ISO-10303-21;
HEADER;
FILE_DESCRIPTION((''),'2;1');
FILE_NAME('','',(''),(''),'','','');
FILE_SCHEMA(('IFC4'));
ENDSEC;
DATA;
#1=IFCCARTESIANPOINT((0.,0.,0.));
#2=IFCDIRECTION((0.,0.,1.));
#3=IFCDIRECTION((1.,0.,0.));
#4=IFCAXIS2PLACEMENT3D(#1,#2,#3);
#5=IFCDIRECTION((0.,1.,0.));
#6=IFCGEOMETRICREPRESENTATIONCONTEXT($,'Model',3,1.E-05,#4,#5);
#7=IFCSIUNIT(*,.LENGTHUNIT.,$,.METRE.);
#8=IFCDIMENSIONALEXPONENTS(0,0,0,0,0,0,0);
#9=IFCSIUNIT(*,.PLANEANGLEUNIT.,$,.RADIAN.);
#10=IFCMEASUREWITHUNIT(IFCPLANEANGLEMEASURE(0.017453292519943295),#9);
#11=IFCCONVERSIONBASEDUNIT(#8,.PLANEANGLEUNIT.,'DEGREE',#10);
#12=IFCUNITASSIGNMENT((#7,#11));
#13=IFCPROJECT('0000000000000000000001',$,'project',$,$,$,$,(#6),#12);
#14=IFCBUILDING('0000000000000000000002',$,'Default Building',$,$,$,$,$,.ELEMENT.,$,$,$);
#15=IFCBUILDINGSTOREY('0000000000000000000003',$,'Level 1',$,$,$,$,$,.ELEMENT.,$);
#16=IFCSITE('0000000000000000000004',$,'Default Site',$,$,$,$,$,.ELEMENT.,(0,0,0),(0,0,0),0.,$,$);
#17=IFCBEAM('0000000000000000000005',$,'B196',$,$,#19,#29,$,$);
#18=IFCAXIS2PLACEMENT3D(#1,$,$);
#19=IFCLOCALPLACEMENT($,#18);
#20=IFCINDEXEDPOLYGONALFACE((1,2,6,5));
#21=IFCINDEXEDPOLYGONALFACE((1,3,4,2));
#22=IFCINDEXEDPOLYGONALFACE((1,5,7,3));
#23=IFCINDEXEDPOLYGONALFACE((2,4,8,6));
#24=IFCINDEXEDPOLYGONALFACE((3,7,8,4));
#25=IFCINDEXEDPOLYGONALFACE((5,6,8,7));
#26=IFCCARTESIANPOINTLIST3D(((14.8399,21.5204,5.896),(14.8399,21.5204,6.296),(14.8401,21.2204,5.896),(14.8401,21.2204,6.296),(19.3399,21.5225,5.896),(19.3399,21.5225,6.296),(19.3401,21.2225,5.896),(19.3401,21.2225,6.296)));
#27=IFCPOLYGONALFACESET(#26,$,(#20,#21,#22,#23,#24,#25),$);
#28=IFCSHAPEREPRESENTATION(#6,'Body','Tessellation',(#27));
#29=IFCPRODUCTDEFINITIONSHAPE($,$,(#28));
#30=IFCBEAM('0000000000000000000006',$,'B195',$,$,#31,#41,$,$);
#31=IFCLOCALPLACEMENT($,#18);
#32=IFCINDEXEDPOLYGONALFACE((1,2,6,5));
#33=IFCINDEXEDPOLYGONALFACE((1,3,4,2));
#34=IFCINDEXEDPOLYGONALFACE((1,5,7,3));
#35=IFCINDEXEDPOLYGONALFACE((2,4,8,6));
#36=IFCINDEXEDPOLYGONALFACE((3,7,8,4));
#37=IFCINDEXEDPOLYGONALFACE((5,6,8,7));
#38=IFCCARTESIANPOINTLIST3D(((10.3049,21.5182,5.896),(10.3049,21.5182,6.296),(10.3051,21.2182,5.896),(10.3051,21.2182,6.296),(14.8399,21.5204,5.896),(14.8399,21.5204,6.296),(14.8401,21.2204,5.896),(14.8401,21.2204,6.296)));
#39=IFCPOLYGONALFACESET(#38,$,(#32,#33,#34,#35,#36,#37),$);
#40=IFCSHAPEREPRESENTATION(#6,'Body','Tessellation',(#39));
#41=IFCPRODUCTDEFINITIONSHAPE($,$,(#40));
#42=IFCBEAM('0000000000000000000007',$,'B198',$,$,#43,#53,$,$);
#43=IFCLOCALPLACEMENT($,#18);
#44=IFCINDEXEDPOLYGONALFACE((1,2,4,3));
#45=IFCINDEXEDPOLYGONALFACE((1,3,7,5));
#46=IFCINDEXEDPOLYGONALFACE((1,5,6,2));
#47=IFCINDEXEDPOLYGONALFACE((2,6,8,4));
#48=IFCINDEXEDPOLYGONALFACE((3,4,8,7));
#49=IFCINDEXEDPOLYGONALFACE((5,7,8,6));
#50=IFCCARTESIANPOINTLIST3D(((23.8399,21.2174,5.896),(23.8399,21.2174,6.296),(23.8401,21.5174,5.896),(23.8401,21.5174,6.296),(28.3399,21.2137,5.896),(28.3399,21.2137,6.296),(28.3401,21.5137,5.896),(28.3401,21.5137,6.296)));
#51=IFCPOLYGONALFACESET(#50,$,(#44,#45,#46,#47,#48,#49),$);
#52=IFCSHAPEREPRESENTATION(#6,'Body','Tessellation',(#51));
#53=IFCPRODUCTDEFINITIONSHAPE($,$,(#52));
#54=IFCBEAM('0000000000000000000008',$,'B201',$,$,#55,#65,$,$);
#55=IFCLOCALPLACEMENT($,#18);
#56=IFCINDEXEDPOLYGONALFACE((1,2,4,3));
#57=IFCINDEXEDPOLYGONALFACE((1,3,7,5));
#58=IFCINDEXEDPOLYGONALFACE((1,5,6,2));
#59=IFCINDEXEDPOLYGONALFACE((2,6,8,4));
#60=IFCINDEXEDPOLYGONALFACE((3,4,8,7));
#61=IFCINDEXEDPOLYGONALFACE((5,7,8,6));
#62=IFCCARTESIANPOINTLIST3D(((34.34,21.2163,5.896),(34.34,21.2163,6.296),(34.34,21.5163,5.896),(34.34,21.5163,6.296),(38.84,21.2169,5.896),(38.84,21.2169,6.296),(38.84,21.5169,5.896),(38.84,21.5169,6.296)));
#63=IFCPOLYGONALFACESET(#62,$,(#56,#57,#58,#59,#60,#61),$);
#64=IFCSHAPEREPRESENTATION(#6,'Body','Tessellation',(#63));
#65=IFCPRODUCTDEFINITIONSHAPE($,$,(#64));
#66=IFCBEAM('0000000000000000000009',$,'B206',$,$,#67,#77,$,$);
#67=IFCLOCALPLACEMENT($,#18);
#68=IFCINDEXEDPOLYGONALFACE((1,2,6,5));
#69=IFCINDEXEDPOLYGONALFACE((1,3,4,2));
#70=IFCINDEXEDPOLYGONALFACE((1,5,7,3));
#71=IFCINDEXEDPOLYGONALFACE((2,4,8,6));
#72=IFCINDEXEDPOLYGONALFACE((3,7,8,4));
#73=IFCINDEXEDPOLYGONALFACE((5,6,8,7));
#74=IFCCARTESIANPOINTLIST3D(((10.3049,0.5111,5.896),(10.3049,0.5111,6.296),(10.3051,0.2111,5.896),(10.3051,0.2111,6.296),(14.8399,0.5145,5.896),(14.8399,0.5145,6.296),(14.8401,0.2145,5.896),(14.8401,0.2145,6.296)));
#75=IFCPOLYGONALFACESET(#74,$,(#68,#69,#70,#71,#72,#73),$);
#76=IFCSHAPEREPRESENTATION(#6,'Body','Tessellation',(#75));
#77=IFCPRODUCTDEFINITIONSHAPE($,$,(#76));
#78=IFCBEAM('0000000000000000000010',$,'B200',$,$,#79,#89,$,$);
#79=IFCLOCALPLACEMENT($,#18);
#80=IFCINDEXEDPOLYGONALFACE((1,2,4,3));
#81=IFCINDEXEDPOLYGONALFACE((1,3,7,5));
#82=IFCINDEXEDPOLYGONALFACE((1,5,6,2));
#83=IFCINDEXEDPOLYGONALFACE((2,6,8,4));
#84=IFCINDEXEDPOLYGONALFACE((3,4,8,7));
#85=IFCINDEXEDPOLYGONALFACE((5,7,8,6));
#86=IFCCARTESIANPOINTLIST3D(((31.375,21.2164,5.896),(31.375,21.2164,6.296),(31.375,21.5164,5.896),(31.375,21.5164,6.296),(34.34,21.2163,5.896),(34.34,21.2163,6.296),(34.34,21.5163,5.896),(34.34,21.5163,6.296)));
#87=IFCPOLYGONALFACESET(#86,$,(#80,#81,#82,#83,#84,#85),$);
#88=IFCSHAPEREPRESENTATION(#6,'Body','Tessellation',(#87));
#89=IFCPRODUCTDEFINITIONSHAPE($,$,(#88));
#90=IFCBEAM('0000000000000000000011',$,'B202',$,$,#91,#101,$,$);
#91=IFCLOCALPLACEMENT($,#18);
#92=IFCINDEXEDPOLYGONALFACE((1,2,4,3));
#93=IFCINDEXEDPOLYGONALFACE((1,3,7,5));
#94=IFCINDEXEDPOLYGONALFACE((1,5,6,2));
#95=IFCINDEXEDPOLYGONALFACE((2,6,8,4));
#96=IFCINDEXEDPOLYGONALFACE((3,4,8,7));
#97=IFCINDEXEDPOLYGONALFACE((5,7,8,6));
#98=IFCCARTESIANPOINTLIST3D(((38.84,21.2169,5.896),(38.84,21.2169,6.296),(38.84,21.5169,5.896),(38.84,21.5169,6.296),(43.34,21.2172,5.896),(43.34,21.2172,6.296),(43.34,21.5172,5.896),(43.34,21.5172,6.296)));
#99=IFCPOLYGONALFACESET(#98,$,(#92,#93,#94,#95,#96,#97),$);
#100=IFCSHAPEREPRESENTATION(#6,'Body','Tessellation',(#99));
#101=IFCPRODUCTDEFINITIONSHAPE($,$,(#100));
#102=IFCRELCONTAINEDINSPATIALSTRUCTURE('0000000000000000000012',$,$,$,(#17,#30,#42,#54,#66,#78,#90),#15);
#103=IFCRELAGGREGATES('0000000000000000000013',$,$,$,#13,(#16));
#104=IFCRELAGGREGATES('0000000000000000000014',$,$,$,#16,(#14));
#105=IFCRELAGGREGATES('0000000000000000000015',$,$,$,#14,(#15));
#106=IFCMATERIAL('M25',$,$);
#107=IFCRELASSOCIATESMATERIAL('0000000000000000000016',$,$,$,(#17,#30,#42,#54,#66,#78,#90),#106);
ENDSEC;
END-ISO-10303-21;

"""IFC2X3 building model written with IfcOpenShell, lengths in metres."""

from ifc_helpers import new_model, entity, si_unit, converted_unit, direction, frame, frame_2d, origin_with_axes, place, context, project, spatial, rectangle, extrude, material, element, save


model = new_model("IFC2X3")

# Units and contexts
model_context = context("Model", 3, precision=1e-05, world=origin_with_axes(), true_north=direction((0.0, 1.0, 0.0)))
ifc_project = project(units=[si_unit("LENGTHUNIT", "METRE"), converted_unit("PLANEANGLEUNIT", "DEGREE", entity("IfcPlaneAngleMeasure", 0.017453292519943295), si_unit("PLANEANGLEUNIT", "RADIAN"), dimensions=[0, 0, 0, 0, 0, 0, 0])], contexts=[model_context])

# Site, building, storey
site = spatial("IfcSite", under=ifc_project, Name="Default Site", CompositionType="ELEMENT", RefLatitude=(0, 0, 0), RefLongitude=(0, 0, 0), RefElevation=0.0)
building = spatial("IfcBuilding", under=site, Name="Default Building", CompositionType="ELEMENT")
storey = spatial("IfcBuildingStorey", under=building, Name="Level 1", CompositionType="ELEMENT")

# Shared definitions
ifc_material = material(Name="M25")
placement = place(None, origin_with_axes())

# Beams
element("IfcBeam", 1, at=placement, inside=storey, material=ifc_material, Name="B196", context=model_context, shape_type="SweptSolid", body=[
    extrude(rectangle(XDim=0.3, YDim=0.4, at=frame_2d((0.0, 0.0), x_axis=(0.0, 1.0, 0.0))), frame((14.84, 21.3704, 6.096), z_axis=(1.0, 0.000471, 0.0), x_axis=(0.0, 0.0, -1.0)), (0.0, 0.0, 1.0), 4.5),
])
element("IfcBeam", 2, at=placement, inside=storey, material=ifc_material, Name="B195", context=model_context, shape_type="SweptSolid", body=[
    extrude(rectangle(XDim=0.3, YDim=0.4, at=frame_2d((0.0, 0.0), x_axis=(0.0, 1.0, 0.0))), frame((10.305, 21.3682, 6.096), z_axis=(1.0, 0.000476, 0.0), x_axis=(0.0, 0.0, -1.0)), (0.0, 0.0, 1.0), 4.535),
])
element("IfcBeam", 3, at=placement, inside=storey, material=ifc_material, Name="B198", context=model_context, shape_type="SweptSolid", body=[
    extrude(rectangle(XDim=0.3, YDim=0.4, at=frame_2d((0.0, 0.0), x_axis=(0.0, 1.0, 0.0))), frame((23.84, 21.3674, 6.096), z_axis=(1.0, -0.000812, 0.0), x_axis=(0.0, 0.0, -1.0)), (0.0, 0.0, 1.0), 4.5),
])
element("IfcBeam", 4, at=placement, inside=storey, material=ifc_material, Name="B201", context=model_context, shape_type="SweptSolid", body=[
    extrude(rectangle(XDim=0.3, YDim=0.4, at=frame_2d((0.0, 0.0), x_axis=(0.0, 1.0, 0.0))), frame((34.34, 21.3663, 6.096), z_axis=(1.0, 0.000136, 0.0), x_axis=(0.0, 0.0, -1.0)), (0.0, 0.0, 1.0), 4.5),
])
element("IfcBeam", 5, at=placement, inside=storey, material=ifc_material, Name="B206", context=model_context, shape_type="SweptSolid", body=[
    extrude(rectangle(XDim=0.3, YDim=0.4, at=frame_2d((0.0, 0.0), x_axis=(0.0, 1.0, 0.0))), frame((10.305, 0.3611, 6.096), z_axis=(1.0, 0.000762, 0.0), x_axis=(0.0, 0.0, -1.0)), (0.0, 0.0, 1.0), 4.535),
])
element("IfcBeam", 6, at=placement, inside=storey, material=ifc_material, Name="B200", context=model_context, shape_type="SweptSolid", body=[
    extrude(rectangle(XDim=0.3, YDim=0.4, at=frame_2d((0.0, 0.0), x_axis=(0.0, 1.0, 0.0))), frame((31.375, 21.3664, 6.096), z_axis=(1.0, -0.000016, 0.0), x_axis=(0.0, 0.0, -1.0)), (0.0, 0.0, 1.0), 2.965),
])
element("IfcBeam", 7, at=placement, inside=storey, material=ifc_material, Name="B202", context=model_context, shape_type="SweptSolid", body=[
    extrude(rectangle(XDim=0.3, YDim=0.4, at=frame_2d((0.0, 0.0), x_axis=(0.0, 1.0, 0.0))), frame((38.84, 21.3669, 6.096), z_axis=(1.0, 0.00005, 0.0), x_axis=(0.0, 0.0, -1.0)), (0.0, 0.0, 1.0), 4.5),
])

save(model, "model.ifc")
